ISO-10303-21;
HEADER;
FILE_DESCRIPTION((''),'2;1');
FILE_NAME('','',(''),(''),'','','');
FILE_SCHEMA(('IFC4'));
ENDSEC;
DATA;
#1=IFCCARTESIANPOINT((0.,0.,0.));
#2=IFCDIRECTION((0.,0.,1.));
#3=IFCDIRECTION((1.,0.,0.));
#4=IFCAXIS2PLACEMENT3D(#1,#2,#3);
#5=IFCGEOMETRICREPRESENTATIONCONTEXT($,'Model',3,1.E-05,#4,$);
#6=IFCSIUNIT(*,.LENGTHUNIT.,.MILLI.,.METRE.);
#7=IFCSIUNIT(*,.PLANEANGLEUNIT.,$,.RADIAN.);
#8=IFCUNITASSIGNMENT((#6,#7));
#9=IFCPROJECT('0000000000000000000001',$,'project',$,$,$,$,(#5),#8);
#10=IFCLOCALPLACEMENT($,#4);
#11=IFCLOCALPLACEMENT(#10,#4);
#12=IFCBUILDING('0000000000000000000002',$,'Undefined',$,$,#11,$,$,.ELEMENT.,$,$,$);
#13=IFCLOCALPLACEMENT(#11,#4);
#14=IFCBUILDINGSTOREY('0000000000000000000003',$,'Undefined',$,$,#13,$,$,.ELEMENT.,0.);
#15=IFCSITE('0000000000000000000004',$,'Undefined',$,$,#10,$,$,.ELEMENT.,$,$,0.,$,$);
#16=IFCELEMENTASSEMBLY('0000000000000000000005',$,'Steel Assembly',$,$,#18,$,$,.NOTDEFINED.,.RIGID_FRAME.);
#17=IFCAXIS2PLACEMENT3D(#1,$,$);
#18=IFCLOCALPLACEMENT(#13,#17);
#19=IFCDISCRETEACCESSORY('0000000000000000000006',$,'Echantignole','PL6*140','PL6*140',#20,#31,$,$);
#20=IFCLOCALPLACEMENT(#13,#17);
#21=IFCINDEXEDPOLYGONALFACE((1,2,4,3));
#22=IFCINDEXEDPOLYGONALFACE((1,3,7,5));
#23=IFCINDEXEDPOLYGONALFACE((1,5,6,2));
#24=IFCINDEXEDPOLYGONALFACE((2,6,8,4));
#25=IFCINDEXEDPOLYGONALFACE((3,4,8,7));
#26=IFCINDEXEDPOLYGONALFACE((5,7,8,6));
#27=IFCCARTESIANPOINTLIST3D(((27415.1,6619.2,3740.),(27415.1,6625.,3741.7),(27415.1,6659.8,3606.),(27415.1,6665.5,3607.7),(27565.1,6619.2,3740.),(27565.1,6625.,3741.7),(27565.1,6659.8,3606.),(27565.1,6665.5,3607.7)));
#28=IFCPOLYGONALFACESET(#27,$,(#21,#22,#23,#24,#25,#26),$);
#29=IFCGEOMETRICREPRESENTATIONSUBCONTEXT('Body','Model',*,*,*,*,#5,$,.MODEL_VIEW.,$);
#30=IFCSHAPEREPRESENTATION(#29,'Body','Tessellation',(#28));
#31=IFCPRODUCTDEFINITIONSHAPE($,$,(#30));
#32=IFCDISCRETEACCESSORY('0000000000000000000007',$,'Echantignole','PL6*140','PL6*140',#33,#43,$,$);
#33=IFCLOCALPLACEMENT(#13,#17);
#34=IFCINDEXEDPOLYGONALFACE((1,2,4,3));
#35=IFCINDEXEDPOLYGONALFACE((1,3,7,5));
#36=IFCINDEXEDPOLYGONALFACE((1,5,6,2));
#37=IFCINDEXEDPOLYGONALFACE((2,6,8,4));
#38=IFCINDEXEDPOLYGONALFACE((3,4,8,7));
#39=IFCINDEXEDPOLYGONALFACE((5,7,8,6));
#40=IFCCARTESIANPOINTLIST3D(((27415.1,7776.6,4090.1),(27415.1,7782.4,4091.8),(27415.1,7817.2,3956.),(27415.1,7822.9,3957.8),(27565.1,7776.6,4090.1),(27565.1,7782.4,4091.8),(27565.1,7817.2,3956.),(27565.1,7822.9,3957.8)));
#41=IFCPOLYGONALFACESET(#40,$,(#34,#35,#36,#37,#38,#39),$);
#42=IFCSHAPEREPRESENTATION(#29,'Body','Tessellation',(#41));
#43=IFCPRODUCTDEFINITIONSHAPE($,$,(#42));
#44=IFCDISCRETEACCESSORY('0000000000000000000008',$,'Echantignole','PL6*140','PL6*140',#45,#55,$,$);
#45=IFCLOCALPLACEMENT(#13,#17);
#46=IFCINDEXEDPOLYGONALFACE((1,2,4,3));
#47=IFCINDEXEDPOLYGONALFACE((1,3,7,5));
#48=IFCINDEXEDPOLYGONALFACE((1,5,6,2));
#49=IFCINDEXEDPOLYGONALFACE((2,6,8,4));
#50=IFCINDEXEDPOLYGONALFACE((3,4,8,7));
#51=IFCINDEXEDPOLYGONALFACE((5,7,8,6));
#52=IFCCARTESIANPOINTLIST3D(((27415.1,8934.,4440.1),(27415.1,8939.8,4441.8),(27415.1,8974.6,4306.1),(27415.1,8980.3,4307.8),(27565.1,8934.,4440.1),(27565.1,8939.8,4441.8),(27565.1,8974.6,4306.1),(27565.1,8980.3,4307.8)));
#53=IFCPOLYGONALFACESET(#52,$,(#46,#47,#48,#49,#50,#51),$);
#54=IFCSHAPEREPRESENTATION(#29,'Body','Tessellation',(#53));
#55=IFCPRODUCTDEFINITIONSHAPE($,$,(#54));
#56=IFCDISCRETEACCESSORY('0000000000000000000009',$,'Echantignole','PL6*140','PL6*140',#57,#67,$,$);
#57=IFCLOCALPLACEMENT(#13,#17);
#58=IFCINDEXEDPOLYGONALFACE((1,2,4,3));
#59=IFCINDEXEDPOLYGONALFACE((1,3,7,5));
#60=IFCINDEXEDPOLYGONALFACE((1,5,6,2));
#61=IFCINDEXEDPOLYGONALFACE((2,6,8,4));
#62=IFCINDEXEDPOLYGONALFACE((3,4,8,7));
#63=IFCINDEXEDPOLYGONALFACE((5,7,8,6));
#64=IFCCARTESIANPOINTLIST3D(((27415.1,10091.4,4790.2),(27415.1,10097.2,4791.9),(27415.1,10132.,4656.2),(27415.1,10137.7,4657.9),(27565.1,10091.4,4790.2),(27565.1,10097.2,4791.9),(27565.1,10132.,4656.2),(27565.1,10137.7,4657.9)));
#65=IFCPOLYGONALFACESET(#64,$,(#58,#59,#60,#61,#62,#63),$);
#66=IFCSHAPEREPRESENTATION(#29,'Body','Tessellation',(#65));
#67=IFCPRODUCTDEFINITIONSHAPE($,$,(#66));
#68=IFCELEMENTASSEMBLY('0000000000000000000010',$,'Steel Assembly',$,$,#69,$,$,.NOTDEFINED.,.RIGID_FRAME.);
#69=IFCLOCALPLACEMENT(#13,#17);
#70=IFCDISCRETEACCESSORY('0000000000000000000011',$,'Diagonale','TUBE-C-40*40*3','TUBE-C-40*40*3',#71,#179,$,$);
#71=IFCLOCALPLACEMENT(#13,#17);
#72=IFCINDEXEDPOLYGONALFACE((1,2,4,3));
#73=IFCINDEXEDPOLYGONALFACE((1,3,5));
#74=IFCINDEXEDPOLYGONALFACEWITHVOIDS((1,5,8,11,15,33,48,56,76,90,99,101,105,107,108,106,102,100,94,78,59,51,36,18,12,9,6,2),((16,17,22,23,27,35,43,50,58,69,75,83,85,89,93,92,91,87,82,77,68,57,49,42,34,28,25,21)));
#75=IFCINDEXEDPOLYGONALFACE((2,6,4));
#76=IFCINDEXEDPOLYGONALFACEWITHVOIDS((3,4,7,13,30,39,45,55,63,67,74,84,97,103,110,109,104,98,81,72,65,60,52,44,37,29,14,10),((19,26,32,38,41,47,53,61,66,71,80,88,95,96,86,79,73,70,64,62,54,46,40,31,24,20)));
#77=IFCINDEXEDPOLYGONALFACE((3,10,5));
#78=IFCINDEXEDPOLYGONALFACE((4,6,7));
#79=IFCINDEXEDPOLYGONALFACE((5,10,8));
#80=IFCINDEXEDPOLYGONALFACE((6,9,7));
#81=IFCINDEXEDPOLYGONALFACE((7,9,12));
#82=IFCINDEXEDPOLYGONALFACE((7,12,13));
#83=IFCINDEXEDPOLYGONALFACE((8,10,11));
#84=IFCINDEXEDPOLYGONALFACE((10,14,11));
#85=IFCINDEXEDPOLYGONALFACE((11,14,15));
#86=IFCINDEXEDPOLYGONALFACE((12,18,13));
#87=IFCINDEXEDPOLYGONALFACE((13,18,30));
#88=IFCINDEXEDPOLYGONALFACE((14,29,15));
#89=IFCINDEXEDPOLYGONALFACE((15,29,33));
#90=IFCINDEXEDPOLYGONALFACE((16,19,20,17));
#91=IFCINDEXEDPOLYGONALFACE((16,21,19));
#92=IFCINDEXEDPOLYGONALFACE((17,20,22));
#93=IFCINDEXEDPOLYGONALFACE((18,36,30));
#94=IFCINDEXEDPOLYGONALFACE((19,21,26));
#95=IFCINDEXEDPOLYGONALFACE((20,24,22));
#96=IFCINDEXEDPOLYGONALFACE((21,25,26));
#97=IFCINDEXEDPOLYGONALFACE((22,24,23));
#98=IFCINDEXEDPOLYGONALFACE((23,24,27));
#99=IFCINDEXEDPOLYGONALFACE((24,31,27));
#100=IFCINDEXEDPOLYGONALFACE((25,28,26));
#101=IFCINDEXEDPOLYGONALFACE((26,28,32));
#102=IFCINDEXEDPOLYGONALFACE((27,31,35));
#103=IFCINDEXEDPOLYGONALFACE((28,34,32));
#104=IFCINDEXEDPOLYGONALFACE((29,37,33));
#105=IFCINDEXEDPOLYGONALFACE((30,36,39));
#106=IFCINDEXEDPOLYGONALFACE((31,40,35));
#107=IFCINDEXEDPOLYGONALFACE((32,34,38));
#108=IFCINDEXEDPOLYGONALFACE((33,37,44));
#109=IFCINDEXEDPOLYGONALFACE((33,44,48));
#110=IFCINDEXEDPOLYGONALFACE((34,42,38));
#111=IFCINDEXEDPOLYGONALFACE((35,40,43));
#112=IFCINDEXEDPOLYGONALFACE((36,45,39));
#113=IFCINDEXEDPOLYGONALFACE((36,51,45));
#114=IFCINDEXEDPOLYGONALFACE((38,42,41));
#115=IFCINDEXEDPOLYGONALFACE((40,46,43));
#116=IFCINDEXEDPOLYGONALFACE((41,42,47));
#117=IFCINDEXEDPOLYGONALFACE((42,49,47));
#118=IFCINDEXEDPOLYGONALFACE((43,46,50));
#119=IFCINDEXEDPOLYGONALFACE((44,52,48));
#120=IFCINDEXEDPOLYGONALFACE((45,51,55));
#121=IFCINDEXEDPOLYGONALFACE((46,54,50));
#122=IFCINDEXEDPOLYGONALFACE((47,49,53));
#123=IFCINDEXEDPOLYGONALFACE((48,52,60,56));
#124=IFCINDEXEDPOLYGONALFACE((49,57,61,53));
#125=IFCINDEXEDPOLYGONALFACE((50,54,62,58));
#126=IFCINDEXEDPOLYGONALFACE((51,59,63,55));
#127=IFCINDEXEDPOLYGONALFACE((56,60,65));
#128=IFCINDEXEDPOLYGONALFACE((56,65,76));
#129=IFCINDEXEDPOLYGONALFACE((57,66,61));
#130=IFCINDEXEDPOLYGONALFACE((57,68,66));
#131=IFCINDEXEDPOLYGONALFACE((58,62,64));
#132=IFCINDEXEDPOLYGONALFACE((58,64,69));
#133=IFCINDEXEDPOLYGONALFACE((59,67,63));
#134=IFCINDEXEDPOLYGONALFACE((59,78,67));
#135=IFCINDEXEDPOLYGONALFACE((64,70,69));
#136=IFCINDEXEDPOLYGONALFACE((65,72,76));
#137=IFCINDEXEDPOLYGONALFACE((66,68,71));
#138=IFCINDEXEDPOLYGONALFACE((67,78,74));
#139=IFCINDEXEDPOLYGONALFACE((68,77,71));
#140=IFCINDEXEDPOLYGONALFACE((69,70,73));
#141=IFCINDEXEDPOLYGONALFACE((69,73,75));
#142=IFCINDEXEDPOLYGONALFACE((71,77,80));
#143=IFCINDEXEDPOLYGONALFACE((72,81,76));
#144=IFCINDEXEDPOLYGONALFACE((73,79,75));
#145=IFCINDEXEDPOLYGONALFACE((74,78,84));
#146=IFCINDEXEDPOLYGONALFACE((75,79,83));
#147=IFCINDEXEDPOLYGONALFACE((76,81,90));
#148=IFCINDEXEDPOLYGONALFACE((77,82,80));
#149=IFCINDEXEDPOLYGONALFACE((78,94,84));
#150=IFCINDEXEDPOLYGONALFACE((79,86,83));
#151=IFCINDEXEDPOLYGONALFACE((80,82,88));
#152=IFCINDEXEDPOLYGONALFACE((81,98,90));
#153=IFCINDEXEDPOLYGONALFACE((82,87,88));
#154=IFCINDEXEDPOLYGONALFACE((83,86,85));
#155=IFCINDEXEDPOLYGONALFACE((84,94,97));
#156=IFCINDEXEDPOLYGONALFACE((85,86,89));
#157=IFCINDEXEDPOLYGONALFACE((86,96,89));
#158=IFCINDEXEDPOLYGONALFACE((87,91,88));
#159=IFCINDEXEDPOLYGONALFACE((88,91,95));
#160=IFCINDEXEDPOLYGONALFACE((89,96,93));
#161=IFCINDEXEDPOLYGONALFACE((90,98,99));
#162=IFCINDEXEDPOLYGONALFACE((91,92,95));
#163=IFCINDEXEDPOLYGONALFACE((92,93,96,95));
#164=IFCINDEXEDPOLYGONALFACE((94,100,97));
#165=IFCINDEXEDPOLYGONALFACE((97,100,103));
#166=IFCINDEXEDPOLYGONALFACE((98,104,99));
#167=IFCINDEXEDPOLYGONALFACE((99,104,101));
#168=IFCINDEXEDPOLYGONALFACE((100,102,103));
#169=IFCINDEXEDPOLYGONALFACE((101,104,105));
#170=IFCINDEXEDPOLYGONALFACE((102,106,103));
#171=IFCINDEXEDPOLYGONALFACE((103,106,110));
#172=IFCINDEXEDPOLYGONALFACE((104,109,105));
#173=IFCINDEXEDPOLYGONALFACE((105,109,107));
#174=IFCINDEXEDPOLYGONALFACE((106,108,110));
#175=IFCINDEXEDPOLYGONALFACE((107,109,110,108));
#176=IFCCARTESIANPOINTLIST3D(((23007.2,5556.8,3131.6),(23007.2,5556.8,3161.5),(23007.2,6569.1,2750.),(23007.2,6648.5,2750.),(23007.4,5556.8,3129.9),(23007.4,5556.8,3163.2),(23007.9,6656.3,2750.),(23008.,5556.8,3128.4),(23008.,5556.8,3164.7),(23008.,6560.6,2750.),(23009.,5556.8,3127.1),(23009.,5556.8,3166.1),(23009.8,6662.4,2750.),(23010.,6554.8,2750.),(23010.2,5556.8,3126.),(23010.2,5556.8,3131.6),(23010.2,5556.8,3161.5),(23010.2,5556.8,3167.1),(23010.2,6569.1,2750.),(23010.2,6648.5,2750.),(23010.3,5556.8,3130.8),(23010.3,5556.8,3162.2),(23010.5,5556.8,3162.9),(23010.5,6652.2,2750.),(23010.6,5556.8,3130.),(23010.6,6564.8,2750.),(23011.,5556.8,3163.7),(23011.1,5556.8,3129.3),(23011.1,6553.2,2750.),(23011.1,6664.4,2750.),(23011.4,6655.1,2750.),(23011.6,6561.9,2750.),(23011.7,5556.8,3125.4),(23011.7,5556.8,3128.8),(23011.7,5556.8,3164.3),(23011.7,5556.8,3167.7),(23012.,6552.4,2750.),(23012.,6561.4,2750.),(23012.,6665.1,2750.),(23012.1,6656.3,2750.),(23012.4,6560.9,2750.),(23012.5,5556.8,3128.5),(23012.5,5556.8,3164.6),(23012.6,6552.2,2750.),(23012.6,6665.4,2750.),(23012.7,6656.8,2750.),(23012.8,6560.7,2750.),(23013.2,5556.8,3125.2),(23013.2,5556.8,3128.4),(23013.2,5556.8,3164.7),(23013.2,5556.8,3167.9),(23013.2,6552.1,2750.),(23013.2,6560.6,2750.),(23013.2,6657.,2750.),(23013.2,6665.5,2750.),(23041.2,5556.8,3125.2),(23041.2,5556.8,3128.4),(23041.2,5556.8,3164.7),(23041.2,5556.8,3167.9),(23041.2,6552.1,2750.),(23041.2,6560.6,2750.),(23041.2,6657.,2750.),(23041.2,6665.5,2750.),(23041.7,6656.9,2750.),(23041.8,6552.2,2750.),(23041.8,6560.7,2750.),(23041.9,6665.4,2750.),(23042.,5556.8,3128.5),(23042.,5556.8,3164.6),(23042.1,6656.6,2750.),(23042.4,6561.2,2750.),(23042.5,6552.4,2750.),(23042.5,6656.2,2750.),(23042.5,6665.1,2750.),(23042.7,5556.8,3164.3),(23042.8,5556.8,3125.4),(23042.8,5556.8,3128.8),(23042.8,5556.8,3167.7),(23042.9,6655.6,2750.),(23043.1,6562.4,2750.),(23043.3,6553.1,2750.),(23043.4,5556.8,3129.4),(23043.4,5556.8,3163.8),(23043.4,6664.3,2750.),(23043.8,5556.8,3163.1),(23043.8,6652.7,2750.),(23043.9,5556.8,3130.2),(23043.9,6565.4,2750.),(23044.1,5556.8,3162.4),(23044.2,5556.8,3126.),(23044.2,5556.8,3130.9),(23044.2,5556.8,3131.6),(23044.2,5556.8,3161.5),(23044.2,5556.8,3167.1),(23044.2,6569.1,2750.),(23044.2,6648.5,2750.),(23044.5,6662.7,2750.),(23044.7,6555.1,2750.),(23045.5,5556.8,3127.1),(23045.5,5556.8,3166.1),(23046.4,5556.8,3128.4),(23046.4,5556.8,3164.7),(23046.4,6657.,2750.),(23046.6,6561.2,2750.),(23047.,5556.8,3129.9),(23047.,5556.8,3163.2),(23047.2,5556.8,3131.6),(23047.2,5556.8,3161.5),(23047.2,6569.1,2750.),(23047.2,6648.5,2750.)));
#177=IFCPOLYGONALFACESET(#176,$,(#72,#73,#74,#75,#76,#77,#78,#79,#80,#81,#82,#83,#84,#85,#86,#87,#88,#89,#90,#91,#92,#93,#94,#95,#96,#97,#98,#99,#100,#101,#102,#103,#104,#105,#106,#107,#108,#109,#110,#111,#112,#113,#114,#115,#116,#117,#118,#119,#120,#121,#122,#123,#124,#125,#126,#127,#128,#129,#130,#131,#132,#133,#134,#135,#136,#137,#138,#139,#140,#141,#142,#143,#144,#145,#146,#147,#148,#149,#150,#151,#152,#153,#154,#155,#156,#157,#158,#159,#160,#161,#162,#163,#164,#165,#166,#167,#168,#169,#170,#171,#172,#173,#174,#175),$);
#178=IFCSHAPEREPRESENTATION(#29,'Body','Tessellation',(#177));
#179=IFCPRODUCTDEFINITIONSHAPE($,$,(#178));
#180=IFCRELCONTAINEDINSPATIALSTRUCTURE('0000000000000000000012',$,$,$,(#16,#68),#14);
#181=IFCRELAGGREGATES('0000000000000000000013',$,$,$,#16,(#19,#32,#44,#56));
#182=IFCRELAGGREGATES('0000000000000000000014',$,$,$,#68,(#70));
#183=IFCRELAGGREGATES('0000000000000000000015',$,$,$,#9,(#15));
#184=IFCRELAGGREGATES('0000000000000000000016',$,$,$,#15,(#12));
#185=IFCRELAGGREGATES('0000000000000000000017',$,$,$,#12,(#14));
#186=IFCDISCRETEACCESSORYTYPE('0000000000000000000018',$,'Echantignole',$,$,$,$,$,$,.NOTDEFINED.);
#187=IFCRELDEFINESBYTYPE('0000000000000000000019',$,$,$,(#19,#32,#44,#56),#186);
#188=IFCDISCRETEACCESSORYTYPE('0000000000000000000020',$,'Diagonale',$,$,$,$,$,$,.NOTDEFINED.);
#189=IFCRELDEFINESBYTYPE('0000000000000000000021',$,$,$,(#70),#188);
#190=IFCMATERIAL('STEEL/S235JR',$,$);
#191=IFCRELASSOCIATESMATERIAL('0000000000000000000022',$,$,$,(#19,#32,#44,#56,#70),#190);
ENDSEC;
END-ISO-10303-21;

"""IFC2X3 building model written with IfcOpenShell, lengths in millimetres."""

from ifc_helpers import new_model, si_unit, frame, origin_with_axes, origin_2d_with_axis, place, context, subcontext, project, spatial, polyline, hollow_rectangle, outline, extrude, clip, halfspace, material, type_object, element, aggregate, save


model = new_model("IFC2X3")

# Units and contexts
model_context = context("Model", 3, precision=1e-05, world=origin_with_axes())
body_context = subcontext(model_context, "Body", "Model", "MODEL_VIEW")
ifc_project = project(units=[si_unit("LENGTHUNIT", "METRE", prefix="MILLI"), si_unit("PLANEANGLEUNIT", "RADIAN")], contexts=[model_context])

# Site, building, storey
site_placement = place(None, origin_with_axes())
site = spatial("IfcSite", under=ifc_project, at=site_placement, Name="Undefined", CompositionType="ELEMENT", RefElevation=0.0)
building_placement = place(site_placement, origin_with_axes())
building = spatial("IfcBuilding", under=site, at=building_placement, Name="Undefined", CompositionType="ELEMENT")
storey_placement = place(building_placement, origin_with_axes())
storey = spatial("IfcBuildingStorey", under=building, at=storey_placement, Name="Undefined", CompositionType="ELEMENT", Elevation=0.0)

# Element assemblies, discrete accessories
assembly_1_placement = place(storey_placement, origin_with_axes())
assembly_1 = element("IfcElementAssembly", 1, at=assembly_1_placement, inside=storey, Name="Steel Assembly", AssemblyPlace="NOTDEFINED", PredefinedType="RIGID_FRAME")
ifc_material_1 = material(Name="STEEL/S235JR")
discrete_accessory_type_1 = type_object("IfcDiscreteAccessoryType", Name="Echantignole")
discrete_accessory_1_placement = place(assembly_1_placement, frame((27415.1, 6642.4, 3673.9), z_axis=(0.0, -0.957179, -0.289497), x_axis=(1.0, 0.0, 0.0)))
discrete_accessory_1 = element("IfcDiscreteAccessory", 2, at=discrete_accessory_1_placement, type_object=discrete_accessory_type_1, material=ifc_material_1, Name="Echantignole", Description="PL6*140", ObjectType="PL6*140", context=body_context, shape_type="SweptSolid", body=[
    extrude(outline(polyline([(150.0, 70.0), (150.0, -70.0), (0.0, -70.0), (0.0, 70.0), (150.0, 70.0)])), frame((0.0, 0.0, -3.0), z_axis=(0.0, 0.0, 1.0), x_axis=(1.0, 0.0, 0.0)), (0.0, 0.0, 1.0), 6.0),
])
discrete_accessory_2_placement = place(assembly_1_placement, frame((27415.1, 7799.8, 4023.9), z_axis=(0.0, -0.957179, -0.289497), x_axis=(1.0, 0.0, 0.0)))
discrete_accessory_2 = element("IfcDiscreteAccessory", 3, at=discrete_accessory_2_placement, type_object=discrete_accessory_type_1, material=ifc_material_1, Name="Echantignole", Description="PL6*140", ObjectType="PL6*140", context=body_context, shape_type="SweptSolid", body=[
    extrude(outline(polyline([(150.0, 70.0), (150.0, -70.0), (0.0, -70.0), (0.0, 70.0), (150.0, 70.0)])), frame((0.0, 0.0, -3.0), z_axis=(0.0, 0.0, 1.0), x_axis=(1.0, 0.0, 0.0)), (0.0, 0.0, 1.0), 6.0),
])
discrete_accessory_3_placement = place(assembly_1_placement, frame((27415.1, 8957.2, 4374.0), z_axis=(0.0, -0.957179, -0.289497), x_axis=(1.0, 0.0, 0.0)))
discrete_accessory_3 = element("IfcDiscreteAccessory", 4, at=discrete_accessory_3_placement, type_object=discrete_accessory_type_1, material=ifc_material_1, Name="Echantignole", Description="PL6*140", ObjectType="PL6*140", context=body_context, shape_type="SweptSolid", body=[
    extrude(outline(polyline([(150.0, 70.0), (150.0, -70.0), (0.0, -70.0), (0.0, 70.0), (150.0, 70.0)])), frame((0.0, 0.0, -3.0), z_axis=(0.0, 0.0, 1.0), x_axis=(1.0, 0.0, 0.0)), (0.0, 0.0, 1.0), 6.0),
])
discrete_accessory_4_placement = place(assembly_1_placement, frame((27415.1, 10114.6, 4724.0), z_axis=(0.0, -0.957179, -0.289497), x_axis=(1.0, 0.0, 0.0)))
discrete_accessory_4 = element("IfcDiscreteAccessory", 5, at=discrete_accessory_4_placement, type_object=discrete_accessory_type_1, material=ifc_material_1, Name="Echantignole", Description="PL6*140", ObjectType="PL6*140", context=body_context, shape_type="SweptSolid", body=[
    extrude(outline(polyline([(150.0, 70.0), (150.0, -70.0), (0.0, -70.0), (0.0, 70.0), (150.0, 70.0)])), frame((0.0, 0.0, -3.0), z_axis=(0.0, 0.0, 1.0), x_axis=(1.0, 0.0, 0.0)), (0.0, 0.0, 1.0), 6.0),
])
aggregate(assembly_1, [discrete_accessory_1, discrete_accessory_2, discrete_accessory_3, discrete_accessory_4])
assembly_2_placement = place(storey_placement, origin_with_axes())
assembly_2 = element("IfcElementAssembly", 6, at=assembly_2_placement, inside=storey, Name="Steel Assembly", AssemblyPlace="NOTDEFINED", PredefinedType="RIGID_FRAME")
discrete_accessory_type_2 = type_object("IfcDiscreteAccessoryType", Name="Diagonale")
discrete_accessory_5_placement = place(assembly_2_placement, frame((23027.2, 6658.4, 2731.3), z_axis=(0.0, 0.352745, 0.93572), x_axis=(0.0, -0.93572, 0.352745)))
discrete_accessory_5 = element("IfcDiscreteAccessory", 7, at=discrete_accessory_5_placement, type_object=discrete_accessory_type_2, material=ifc_material_1, Name="Diagonale", Description="TUBE-C-40*40*3", ObjectType="TUBE-C-40*40*3", context=body_context, shape_type="Clipping", body=[
    clip(clip(extrude(hollow_rectangle(XDim=40.0, YDim=40.0, WallThickness=3.0, InnerFilletRadius=3.0, OuterFilletRadius=6.0, at=origin_2d_with_axis()), frame((1238.5, 0.0, 0.0), z_axis=(-1.0, 0.0, 0.0), x_axis=(0.0, -1.0, 0.0)), (0.0, 0.0, 1.0), 1246.6), halfspace(frame((1146.9, 0.0, -80.5), z_axis=(0.93572, 0.0, -0.352745), x_axis=(0.352745, 0.0, 0.93572)), False)), halfspace(frame((172.4, 0.0, -45.0), z_axis=(0.352745, 0.0, 0.93572), x_axis=(-0.93572, 0.0, 0.352745)), True)),
])
aggregate(assembly_2, [discrete_accessory_5])

save(model, "model.ifc")
